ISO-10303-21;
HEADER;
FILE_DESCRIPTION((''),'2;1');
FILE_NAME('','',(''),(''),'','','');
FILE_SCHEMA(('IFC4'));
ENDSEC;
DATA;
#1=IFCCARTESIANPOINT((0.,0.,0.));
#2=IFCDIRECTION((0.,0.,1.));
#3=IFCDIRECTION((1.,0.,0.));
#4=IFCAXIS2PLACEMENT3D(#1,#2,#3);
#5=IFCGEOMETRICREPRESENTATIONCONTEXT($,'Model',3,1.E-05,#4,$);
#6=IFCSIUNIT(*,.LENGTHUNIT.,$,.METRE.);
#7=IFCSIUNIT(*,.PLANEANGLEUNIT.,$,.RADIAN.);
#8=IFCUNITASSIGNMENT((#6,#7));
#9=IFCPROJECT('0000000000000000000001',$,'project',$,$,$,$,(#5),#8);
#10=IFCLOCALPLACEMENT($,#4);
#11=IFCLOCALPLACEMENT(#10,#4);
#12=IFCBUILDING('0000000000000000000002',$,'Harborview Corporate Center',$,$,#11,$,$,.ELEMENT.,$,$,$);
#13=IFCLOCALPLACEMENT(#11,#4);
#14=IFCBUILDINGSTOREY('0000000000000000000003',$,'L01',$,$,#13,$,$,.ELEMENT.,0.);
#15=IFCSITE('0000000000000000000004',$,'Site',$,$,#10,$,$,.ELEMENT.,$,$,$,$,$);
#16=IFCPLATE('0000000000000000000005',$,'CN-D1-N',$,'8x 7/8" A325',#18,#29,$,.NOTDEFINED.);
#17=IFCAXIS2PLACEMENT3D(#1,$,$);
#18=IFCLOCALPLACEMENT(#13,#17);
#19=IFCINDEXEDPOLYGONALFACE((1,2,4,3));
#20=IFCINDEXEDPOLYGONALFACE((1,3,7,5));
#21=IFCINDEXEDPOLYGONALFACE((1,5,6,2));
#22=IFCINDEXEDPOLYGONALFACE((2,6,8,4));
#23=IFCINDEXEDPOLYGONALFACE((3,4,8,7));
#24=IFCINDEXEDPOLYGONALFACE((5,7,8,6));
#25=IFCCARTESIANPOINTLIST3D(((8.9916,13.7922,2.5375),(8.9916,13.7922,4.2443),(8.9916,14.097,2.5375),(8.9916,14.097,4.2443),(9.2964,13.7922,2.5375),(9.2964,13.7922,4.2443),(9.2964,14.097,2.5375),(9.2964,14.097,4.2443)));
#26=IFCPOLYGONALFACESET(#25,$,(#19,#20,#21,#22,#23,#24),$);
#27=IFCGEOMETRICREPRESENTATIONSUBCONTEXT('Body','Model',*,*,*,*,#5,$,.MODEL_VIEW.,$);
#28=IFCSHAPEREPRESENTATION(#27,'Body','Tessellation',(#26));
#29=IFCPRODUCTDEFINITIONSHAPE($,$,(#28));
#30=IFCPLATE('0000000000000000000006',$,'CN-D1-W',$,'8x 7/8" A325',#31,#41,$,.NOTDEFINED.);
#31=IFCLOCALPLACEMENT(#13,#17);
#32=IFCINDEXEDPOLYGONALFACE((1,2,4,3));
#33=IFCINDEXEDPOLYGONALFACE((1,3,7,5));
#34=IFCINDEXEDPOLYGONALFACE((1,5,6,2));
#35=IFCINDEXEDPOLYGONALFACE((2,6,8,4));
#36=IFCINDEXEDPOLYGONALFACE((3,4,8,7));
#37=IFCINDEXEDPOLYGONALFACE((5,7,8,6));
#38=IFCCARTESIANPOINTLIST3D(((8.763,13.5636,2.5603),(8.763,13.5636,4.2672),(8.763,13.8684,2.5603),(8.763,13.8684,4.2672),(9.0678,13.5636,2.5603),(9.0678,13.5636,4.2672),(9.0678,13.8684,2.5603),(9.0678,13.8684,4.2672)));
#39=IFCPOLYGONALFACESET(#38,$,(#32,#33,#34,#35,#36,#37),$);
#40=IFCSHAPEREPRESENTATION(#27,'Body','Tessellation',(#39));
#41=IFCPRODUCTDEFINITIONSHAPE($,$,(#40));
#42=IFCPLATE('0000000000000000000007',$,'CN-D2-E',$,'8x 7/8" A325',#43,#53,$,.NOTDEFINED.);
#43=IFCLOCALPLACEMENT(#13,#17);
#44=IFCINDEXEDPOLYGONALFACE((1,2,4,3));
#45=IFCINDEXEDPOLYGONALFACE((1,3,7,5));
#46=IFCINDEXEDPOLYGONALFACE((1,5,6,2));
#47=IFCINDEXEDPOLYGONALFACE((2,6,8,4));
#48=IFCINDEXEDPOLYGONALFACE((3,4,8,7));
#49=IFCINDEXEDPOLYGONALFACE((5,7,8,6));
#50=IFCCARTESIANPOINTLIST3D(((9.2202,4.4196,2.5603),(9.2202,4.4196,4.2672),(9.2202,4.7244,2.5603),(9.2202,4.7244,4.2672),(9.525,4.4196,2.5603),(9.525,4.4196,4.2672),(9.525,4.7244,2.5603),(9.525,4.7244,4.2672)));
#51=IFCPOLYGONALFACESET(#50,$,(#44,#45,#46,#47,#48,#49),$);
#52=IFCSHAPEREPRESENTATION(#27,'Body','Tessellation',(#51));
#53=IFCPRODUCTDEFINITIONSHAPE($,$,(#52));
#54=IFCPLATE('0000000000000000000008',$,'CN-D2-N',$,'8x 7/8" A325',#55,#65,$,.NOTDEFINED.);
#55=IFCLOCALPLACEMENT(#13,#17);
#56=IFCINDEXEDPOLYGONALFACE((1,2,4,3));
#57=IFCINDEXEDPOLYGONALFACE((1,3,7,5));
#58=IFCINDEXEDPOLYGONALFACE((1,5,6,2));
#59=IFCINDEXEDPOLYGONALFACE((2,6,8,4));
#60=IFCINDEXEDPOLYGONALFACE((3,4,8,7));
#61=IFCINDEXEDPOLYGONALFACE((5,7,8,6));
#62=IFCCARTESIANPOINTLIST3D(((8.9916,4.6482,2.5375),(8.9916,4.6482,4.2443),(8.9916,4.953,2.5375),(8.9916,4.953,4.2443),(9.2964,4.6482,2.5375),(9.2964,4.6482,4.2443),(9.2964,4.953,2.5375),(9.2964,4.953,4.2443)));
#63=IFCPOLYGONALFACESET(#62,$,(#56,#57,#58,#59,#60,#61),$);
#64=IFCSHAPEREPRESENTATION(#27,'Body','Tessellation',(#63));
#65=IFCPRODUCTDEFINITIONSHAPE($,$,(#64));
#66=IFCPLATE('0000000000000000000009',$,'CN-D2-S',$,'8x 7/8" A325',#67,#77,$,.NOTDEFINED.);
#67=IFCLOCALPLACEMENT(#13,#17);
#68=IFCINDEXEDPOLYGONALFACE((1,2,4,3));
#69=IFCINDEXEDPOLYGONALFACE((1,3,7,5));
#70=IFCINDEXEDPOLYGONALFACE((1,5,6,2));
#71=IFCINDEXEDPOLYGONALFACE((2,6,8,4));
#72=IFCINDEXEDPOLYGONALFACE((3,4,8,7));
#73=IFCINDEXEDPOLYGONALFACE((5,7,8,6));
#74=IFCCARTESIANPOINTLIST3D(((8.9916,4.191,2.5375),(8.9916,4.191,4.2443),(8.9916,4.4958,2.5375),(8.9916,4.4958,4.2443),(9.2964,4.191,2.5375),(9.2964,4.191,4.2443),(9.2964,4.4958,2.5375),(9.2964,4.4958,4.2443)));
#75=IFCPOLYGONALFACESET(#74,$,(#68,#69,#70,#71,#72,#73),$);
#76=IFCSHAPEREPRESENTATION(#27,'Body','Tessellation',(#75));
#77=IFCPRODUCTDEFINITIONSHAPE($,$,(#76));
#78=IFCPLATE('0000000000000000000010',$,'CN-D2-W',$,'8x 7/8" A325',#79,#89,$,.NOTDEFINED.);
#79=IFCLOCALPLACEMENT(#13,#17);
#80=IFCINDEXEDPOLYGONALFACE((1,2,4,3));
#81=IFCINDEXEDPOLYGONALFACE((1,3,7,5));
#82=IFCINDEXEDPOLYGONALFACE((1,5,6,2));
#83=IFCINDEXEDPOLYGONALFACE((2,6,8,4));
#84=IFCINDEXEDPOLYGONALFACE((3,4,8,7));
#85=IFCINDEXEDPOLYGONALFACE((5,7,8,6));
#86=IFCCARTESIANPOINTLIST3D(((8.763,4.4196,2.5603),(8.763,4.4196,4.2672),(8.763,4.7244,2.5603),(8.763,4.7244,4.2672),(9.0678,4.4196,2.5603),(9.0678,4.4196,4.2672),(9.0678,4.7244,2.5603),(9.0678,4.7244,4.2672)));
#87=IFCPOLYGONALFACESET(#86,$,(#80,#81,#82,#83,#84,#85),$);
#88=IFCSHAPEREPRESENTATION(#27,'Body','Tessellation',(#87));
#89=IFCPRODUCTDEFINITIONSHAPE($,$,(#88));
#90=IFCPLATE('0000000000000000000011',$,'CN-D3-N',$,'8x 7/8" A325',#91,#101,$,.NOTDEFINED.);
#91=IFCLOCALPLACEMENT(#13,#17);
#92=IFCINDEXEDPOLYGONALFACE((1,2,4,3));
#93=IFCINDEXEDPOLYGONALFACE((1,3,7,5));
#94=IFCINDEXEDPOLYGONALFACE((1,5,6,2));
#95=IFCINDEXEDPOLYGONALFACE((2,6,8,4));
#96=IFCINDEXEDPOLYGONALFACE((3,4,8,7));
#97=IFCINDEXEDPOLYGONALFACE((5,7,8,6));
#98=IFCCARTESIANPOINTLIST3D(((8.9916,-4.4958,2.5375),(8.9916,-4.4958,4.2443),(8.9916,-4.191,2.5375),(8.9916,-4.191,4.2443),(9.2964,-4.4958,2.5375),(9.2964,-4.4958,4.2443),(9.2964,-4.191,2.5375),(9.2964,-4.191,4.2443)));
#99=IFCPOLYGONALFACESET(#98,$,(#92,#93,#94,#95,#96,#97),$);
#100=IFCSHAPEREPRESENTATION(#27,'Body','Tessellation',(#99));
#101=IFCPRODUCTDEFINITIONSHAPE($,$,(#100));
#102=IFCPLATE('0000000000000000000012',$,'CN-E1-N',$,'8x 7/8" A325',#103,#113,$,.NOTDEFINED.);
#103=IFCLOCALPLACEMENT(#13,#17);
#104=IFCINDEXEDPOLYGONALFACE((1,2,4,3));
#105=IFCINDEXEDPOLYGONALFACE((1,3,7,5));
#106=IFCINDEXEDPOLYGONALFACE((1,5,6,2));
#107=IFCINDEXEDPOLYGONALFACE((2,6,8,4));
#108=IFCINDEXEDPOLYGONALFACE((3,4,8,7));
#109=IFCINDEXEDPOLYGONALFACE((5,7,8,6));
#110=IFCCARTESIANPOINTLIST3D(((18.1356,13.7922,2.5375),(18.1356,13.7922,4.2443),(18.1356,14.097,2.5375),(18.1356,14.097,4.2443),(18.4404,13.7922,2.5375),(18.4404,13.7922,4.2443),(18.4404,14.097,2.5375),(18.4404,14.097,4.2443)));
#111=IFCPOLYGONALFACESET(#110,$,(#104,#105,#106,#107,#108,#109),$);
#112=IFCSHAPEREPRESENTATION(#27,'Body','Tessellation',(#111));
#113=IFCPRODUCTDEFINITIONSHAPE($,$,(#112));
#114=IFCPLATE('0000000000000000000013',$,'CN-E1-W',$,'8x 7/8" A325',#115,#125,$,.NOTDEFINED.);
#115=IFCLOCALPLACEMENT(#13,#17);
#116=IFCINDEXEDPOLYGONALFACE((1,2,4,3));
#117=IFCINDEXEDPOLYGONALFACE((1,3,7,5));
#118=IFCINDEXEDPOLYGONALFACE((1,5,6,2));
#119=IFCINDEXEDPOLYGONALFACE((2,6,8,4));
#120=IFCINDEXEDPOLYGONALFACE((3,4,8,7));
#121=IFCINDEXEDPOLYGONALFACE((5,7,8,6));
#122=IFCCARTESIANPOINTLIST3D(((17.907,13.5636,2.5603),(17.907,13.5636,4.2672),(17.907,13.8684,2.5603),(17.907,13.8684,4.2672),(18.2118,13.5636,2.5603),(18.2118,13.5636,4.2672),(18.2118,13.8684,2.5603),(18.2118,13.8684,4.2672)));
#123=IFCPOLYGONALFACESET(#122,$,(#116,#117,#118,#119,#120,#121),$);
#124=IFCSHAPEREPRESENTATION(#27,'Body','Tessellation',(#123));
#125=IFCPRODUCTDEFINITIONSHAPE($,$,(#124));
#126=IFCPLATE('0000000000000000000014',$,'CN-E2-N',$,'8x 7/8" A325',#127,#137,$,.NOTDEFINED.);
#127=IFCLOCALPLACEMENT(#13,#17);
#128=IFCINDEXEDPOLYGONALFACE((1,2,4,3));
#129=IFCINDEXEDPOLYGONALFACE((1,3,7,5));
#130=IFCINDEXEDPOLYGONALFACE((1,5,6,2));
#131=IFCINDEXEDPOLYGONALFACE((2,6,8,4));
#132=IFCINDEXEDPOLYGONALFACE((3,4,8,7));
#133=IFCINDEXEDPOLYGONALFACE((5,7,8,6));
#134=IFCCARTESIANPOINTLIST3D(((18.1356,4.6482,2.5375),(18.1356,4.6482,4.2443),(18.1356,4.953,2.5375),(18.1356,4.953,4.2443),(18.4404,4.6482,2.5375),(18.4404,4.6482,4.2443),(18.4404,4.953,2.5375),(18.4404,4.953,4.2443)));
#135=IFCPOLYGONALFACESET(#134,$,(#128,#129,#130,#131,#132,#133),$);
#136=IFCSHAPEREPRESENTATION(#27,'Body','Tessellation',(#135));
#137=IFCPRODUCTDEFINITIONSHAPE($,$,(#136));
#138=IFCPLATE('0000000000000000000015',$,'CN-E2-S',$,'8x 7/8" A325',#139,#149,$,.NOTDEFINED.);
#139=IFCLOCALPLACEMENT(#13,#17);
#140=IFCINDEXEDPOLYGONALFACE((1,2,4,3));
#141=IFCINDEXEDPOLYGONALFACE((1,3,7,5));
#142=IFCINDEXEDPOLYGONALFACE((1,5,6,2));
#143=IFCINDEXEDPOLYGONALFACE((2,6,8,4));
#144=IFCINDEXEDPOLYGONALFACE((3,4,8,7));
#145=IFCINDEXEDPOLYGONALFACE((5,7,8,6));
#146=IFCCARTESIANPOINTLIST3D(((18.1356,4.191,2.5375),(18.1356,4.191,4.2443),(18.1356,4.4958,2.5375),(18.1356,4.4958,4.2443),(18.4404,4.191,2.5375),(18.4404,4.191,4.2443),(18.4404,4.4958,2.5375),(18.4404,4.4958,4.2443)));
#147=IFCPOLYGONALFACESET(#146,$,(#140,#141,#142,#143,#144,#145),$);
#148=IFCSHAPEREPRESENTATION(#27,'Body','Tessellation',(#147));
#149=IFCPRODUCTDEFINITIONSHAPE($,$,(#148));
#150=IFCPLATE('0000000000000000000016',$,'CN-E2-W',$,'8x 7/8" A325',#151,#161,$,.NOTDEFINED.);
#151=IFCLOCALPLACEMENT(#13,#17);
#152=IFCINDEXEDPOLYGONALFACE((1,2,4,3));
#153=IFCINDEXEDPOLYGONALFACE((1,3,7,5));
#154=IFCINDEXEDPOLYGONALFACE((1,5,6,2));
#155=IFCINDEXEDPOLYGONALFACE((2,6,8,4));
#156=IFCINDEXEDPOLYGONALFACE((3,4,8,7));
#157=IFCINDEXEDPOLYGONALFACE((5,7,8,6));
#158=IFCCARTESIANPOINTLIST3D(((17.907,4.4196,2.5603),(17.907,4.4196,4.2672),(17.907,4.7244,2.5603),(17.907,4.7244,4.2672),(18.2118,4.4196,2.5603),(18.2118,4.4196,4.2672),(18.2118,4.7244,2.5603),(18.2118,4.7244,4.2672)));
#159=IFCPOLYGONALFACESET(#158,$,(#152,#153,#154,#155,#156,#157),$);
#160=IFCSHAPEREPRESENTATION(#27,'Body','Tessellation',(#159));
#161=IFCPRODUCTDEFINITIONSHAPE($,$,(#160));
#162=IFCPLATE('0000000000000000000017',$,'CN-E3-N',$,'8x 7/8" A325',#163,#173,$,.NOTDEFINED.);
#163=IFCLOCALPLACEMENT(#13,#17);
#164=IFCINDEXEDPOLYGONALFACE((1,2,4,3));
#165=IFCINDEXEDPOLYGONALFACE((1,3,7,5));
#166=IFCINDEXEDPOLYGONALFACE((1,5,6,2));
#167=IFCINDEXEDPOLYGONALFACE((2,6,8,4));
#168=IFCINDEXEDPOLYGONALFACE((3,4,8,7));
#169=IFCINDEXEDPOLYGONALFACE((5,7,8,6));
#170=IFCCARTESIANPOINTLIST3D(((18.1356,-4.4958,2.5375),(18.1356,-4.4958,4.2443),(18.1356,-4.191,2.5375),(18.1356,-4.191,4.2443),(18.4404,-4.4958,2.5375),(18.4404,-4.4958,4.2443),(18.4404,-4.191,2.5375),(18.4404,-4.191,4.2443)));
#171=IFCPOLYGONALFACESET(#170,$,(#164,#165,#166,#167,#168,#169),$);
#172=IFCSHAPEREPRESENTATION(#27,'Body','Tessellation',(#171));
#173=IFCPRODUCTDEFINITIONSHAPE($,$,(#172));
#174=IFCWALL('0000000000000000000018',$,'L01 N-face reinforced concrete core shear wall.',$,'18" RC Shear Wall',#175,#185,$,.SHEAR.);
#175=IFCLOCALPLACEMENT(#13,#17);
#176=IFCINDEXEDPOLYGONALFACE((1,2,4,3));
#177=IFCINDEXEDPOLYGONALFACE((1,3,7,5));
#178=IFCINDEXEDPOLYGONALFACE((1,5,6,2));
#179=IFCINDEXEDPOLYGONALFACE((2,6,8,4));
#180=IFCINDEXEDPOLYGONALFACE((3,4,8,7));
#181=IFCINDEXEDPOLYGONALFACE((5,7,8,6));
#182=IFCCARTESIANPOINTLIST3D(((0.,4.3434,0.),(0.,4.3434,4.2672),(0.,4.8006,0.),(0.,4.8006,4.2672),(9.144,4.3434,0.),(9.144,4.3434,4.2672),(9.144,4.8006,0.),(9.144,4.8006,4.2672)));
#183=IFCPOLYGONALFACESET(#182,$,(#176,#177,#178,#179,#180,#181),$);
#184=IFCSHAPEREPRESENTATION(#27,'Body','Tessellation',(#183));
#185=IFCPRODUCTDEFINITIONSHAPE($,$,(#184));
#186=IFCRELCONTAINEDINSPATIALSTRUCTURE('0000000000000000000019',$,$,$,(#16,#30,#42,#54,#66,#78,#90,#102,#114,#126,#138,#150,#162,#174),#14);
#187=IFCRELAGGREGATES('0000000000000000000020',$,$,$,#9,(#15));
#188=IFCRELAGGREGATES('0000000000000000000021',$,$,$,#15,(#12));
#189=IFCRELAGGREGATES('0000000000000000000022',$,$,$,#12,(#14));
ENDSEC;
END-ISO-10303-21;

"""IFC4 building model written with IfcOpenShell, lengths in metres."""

from ifc_helpers import new_model, si_unit, frame, origin_with_axes, place, context, subcontext, project, spatial, rectangle, extrude, element, save


model = new_model("IFC4")

# Units and contexts
model_context = context("Model", 3, precision=1e-05, world=origin_with_axes())
body_context = subcontext(model_context, "Body", "Model", "MODEL_VIEW")
ifc_project = project(units=[si_unit("LENGTHUNIT", "METRE"), si_unit("PLANEANGLEUNIT", "RADIAN")], contexts=[model_context])

# Site, building, storey
site_placement = place(None, origin_with_axes())
site = spatial("IfcSite", under=ifc_project, at=site_placement, Name="Site", CompositionType="ELEMENT")
building_placement = place(site_placement, origin_with_axes())
building = spatial("IfcBuilding", under=site, at=building_placement, Name="Harborview Corporate Center", CompositionType="ELEMENT")
storey_placement = place(building_placement, origin_with_axes())
storey = spatial("IfcBuildingStorey", under=building, at=storey_placement, Name="L01", CompositionType="ELEMENT", Elevation=0.0)

# Plates
for number, where, z_axis, x_axis, name in (
    (1, (9.144, 13.9446, 2.5375), (0.0, 0.0, 1.0), (1.0, 0.0, 0.0), "CN-D1-N"),
    (2, (8.9154, 13.716, 2.5603), (0.0, 0.0, 1.0), (1.0, 0.0, 0.0), "CN-D1-W"),
    (3, (9.3726, 4.572, 2.5603), (0.0, 0.0, 1.0), (1.0, 0.0, 0.0), "CN-D2-E"),
    (4, (9.144, 4.8006, 2.5375), (0.0, 0.0, 1.0), (1.0, 0.0, 0.0), "CN-D2-N"),
    (5, (9.144, 4.3434, 2.5375), (0.0, 0.0, 1.0), (1.0, 0.0, 0.0), "CN-D2-S"),
    (6, (8.9154, 4.572, 2.5603), (0.0, 0.0, 1.0), (1.0, 0.0, 0.0), "CN-D2-W"),
    (7, (9.144, -4.3434, 2.5375), (0.0, 0.0, 1.0), (1.0, 0.0, 0.0), "CN-D3-N"),
    (8, (18.288, 13.9446, 2.5375), (0.0, 0.0, 1.0), (1.0, 0.0, 0.0), "CN-E1-N"),
    (9, (18.0594, 13.716, 2.5603), (0.0, 0.0, 1.0), (1.0, 0.0, 0.0), "CN-E1-W"),
    (10, (18.288, 4.8006, 2.5375), (0.0, 0.0, 1.0), (1.0, 0.0, 0.0), "CN-E2-N"),
    (11, (18.288, 4.3434, 2.5375), (0.0, 0.0, 1.0), (1.0, 0.0, 0.0), "CN-E2-S"),
    (12, (18.0594, 4.572, 2.5603), (0.0, 0.0, 1.0), (1.0, 0.0, 0.0), "CN-E2-W"),
    (13, (18.288, -4.3434, 2.5375), (0.0, 0.0, 1.0), (1.0, 0.0, 0.0), "CN-E3-N"),
):
    element("IfcPlate", number, at=place(storey_placement, frame(where, z_axis=z_axis, x_axis=x_axis)), inside=storey, Name=name, ObjectType="8x 7/8\" A325", PredefinedType="NOTDEFINED", context=body_context, shape_type="SweptSolid", body=[
        extrude(rectangle(XDim=0.3048, YDim=0.3048), origin_with_axes(), (0.0, 0.0, 1.0), 1.7069),
    ])

# Wall
wall_placement = place(storey_placement, frame((4.572, 4.572, 0.0), z_axis=(0.0, 0.0, 1.0), x_axis=(1.0, 0.0, 0.0)))
element("IfcWall", 14, at=wall_placement, inside=storey, Name="L01 N-face reinforced concrete core shear wall.", ObjectType="18\" RC Shear Wall", PredefinedType="SHEAR", context=body_context, shape_type="SweptSolid", body=[
    extrude(rectangle(XDim=9.144, YDim=0.4572), origin_with_axes(), (0.0, 0.0, 1.0), 4.2672),
])

save(model, "model.ifc")
